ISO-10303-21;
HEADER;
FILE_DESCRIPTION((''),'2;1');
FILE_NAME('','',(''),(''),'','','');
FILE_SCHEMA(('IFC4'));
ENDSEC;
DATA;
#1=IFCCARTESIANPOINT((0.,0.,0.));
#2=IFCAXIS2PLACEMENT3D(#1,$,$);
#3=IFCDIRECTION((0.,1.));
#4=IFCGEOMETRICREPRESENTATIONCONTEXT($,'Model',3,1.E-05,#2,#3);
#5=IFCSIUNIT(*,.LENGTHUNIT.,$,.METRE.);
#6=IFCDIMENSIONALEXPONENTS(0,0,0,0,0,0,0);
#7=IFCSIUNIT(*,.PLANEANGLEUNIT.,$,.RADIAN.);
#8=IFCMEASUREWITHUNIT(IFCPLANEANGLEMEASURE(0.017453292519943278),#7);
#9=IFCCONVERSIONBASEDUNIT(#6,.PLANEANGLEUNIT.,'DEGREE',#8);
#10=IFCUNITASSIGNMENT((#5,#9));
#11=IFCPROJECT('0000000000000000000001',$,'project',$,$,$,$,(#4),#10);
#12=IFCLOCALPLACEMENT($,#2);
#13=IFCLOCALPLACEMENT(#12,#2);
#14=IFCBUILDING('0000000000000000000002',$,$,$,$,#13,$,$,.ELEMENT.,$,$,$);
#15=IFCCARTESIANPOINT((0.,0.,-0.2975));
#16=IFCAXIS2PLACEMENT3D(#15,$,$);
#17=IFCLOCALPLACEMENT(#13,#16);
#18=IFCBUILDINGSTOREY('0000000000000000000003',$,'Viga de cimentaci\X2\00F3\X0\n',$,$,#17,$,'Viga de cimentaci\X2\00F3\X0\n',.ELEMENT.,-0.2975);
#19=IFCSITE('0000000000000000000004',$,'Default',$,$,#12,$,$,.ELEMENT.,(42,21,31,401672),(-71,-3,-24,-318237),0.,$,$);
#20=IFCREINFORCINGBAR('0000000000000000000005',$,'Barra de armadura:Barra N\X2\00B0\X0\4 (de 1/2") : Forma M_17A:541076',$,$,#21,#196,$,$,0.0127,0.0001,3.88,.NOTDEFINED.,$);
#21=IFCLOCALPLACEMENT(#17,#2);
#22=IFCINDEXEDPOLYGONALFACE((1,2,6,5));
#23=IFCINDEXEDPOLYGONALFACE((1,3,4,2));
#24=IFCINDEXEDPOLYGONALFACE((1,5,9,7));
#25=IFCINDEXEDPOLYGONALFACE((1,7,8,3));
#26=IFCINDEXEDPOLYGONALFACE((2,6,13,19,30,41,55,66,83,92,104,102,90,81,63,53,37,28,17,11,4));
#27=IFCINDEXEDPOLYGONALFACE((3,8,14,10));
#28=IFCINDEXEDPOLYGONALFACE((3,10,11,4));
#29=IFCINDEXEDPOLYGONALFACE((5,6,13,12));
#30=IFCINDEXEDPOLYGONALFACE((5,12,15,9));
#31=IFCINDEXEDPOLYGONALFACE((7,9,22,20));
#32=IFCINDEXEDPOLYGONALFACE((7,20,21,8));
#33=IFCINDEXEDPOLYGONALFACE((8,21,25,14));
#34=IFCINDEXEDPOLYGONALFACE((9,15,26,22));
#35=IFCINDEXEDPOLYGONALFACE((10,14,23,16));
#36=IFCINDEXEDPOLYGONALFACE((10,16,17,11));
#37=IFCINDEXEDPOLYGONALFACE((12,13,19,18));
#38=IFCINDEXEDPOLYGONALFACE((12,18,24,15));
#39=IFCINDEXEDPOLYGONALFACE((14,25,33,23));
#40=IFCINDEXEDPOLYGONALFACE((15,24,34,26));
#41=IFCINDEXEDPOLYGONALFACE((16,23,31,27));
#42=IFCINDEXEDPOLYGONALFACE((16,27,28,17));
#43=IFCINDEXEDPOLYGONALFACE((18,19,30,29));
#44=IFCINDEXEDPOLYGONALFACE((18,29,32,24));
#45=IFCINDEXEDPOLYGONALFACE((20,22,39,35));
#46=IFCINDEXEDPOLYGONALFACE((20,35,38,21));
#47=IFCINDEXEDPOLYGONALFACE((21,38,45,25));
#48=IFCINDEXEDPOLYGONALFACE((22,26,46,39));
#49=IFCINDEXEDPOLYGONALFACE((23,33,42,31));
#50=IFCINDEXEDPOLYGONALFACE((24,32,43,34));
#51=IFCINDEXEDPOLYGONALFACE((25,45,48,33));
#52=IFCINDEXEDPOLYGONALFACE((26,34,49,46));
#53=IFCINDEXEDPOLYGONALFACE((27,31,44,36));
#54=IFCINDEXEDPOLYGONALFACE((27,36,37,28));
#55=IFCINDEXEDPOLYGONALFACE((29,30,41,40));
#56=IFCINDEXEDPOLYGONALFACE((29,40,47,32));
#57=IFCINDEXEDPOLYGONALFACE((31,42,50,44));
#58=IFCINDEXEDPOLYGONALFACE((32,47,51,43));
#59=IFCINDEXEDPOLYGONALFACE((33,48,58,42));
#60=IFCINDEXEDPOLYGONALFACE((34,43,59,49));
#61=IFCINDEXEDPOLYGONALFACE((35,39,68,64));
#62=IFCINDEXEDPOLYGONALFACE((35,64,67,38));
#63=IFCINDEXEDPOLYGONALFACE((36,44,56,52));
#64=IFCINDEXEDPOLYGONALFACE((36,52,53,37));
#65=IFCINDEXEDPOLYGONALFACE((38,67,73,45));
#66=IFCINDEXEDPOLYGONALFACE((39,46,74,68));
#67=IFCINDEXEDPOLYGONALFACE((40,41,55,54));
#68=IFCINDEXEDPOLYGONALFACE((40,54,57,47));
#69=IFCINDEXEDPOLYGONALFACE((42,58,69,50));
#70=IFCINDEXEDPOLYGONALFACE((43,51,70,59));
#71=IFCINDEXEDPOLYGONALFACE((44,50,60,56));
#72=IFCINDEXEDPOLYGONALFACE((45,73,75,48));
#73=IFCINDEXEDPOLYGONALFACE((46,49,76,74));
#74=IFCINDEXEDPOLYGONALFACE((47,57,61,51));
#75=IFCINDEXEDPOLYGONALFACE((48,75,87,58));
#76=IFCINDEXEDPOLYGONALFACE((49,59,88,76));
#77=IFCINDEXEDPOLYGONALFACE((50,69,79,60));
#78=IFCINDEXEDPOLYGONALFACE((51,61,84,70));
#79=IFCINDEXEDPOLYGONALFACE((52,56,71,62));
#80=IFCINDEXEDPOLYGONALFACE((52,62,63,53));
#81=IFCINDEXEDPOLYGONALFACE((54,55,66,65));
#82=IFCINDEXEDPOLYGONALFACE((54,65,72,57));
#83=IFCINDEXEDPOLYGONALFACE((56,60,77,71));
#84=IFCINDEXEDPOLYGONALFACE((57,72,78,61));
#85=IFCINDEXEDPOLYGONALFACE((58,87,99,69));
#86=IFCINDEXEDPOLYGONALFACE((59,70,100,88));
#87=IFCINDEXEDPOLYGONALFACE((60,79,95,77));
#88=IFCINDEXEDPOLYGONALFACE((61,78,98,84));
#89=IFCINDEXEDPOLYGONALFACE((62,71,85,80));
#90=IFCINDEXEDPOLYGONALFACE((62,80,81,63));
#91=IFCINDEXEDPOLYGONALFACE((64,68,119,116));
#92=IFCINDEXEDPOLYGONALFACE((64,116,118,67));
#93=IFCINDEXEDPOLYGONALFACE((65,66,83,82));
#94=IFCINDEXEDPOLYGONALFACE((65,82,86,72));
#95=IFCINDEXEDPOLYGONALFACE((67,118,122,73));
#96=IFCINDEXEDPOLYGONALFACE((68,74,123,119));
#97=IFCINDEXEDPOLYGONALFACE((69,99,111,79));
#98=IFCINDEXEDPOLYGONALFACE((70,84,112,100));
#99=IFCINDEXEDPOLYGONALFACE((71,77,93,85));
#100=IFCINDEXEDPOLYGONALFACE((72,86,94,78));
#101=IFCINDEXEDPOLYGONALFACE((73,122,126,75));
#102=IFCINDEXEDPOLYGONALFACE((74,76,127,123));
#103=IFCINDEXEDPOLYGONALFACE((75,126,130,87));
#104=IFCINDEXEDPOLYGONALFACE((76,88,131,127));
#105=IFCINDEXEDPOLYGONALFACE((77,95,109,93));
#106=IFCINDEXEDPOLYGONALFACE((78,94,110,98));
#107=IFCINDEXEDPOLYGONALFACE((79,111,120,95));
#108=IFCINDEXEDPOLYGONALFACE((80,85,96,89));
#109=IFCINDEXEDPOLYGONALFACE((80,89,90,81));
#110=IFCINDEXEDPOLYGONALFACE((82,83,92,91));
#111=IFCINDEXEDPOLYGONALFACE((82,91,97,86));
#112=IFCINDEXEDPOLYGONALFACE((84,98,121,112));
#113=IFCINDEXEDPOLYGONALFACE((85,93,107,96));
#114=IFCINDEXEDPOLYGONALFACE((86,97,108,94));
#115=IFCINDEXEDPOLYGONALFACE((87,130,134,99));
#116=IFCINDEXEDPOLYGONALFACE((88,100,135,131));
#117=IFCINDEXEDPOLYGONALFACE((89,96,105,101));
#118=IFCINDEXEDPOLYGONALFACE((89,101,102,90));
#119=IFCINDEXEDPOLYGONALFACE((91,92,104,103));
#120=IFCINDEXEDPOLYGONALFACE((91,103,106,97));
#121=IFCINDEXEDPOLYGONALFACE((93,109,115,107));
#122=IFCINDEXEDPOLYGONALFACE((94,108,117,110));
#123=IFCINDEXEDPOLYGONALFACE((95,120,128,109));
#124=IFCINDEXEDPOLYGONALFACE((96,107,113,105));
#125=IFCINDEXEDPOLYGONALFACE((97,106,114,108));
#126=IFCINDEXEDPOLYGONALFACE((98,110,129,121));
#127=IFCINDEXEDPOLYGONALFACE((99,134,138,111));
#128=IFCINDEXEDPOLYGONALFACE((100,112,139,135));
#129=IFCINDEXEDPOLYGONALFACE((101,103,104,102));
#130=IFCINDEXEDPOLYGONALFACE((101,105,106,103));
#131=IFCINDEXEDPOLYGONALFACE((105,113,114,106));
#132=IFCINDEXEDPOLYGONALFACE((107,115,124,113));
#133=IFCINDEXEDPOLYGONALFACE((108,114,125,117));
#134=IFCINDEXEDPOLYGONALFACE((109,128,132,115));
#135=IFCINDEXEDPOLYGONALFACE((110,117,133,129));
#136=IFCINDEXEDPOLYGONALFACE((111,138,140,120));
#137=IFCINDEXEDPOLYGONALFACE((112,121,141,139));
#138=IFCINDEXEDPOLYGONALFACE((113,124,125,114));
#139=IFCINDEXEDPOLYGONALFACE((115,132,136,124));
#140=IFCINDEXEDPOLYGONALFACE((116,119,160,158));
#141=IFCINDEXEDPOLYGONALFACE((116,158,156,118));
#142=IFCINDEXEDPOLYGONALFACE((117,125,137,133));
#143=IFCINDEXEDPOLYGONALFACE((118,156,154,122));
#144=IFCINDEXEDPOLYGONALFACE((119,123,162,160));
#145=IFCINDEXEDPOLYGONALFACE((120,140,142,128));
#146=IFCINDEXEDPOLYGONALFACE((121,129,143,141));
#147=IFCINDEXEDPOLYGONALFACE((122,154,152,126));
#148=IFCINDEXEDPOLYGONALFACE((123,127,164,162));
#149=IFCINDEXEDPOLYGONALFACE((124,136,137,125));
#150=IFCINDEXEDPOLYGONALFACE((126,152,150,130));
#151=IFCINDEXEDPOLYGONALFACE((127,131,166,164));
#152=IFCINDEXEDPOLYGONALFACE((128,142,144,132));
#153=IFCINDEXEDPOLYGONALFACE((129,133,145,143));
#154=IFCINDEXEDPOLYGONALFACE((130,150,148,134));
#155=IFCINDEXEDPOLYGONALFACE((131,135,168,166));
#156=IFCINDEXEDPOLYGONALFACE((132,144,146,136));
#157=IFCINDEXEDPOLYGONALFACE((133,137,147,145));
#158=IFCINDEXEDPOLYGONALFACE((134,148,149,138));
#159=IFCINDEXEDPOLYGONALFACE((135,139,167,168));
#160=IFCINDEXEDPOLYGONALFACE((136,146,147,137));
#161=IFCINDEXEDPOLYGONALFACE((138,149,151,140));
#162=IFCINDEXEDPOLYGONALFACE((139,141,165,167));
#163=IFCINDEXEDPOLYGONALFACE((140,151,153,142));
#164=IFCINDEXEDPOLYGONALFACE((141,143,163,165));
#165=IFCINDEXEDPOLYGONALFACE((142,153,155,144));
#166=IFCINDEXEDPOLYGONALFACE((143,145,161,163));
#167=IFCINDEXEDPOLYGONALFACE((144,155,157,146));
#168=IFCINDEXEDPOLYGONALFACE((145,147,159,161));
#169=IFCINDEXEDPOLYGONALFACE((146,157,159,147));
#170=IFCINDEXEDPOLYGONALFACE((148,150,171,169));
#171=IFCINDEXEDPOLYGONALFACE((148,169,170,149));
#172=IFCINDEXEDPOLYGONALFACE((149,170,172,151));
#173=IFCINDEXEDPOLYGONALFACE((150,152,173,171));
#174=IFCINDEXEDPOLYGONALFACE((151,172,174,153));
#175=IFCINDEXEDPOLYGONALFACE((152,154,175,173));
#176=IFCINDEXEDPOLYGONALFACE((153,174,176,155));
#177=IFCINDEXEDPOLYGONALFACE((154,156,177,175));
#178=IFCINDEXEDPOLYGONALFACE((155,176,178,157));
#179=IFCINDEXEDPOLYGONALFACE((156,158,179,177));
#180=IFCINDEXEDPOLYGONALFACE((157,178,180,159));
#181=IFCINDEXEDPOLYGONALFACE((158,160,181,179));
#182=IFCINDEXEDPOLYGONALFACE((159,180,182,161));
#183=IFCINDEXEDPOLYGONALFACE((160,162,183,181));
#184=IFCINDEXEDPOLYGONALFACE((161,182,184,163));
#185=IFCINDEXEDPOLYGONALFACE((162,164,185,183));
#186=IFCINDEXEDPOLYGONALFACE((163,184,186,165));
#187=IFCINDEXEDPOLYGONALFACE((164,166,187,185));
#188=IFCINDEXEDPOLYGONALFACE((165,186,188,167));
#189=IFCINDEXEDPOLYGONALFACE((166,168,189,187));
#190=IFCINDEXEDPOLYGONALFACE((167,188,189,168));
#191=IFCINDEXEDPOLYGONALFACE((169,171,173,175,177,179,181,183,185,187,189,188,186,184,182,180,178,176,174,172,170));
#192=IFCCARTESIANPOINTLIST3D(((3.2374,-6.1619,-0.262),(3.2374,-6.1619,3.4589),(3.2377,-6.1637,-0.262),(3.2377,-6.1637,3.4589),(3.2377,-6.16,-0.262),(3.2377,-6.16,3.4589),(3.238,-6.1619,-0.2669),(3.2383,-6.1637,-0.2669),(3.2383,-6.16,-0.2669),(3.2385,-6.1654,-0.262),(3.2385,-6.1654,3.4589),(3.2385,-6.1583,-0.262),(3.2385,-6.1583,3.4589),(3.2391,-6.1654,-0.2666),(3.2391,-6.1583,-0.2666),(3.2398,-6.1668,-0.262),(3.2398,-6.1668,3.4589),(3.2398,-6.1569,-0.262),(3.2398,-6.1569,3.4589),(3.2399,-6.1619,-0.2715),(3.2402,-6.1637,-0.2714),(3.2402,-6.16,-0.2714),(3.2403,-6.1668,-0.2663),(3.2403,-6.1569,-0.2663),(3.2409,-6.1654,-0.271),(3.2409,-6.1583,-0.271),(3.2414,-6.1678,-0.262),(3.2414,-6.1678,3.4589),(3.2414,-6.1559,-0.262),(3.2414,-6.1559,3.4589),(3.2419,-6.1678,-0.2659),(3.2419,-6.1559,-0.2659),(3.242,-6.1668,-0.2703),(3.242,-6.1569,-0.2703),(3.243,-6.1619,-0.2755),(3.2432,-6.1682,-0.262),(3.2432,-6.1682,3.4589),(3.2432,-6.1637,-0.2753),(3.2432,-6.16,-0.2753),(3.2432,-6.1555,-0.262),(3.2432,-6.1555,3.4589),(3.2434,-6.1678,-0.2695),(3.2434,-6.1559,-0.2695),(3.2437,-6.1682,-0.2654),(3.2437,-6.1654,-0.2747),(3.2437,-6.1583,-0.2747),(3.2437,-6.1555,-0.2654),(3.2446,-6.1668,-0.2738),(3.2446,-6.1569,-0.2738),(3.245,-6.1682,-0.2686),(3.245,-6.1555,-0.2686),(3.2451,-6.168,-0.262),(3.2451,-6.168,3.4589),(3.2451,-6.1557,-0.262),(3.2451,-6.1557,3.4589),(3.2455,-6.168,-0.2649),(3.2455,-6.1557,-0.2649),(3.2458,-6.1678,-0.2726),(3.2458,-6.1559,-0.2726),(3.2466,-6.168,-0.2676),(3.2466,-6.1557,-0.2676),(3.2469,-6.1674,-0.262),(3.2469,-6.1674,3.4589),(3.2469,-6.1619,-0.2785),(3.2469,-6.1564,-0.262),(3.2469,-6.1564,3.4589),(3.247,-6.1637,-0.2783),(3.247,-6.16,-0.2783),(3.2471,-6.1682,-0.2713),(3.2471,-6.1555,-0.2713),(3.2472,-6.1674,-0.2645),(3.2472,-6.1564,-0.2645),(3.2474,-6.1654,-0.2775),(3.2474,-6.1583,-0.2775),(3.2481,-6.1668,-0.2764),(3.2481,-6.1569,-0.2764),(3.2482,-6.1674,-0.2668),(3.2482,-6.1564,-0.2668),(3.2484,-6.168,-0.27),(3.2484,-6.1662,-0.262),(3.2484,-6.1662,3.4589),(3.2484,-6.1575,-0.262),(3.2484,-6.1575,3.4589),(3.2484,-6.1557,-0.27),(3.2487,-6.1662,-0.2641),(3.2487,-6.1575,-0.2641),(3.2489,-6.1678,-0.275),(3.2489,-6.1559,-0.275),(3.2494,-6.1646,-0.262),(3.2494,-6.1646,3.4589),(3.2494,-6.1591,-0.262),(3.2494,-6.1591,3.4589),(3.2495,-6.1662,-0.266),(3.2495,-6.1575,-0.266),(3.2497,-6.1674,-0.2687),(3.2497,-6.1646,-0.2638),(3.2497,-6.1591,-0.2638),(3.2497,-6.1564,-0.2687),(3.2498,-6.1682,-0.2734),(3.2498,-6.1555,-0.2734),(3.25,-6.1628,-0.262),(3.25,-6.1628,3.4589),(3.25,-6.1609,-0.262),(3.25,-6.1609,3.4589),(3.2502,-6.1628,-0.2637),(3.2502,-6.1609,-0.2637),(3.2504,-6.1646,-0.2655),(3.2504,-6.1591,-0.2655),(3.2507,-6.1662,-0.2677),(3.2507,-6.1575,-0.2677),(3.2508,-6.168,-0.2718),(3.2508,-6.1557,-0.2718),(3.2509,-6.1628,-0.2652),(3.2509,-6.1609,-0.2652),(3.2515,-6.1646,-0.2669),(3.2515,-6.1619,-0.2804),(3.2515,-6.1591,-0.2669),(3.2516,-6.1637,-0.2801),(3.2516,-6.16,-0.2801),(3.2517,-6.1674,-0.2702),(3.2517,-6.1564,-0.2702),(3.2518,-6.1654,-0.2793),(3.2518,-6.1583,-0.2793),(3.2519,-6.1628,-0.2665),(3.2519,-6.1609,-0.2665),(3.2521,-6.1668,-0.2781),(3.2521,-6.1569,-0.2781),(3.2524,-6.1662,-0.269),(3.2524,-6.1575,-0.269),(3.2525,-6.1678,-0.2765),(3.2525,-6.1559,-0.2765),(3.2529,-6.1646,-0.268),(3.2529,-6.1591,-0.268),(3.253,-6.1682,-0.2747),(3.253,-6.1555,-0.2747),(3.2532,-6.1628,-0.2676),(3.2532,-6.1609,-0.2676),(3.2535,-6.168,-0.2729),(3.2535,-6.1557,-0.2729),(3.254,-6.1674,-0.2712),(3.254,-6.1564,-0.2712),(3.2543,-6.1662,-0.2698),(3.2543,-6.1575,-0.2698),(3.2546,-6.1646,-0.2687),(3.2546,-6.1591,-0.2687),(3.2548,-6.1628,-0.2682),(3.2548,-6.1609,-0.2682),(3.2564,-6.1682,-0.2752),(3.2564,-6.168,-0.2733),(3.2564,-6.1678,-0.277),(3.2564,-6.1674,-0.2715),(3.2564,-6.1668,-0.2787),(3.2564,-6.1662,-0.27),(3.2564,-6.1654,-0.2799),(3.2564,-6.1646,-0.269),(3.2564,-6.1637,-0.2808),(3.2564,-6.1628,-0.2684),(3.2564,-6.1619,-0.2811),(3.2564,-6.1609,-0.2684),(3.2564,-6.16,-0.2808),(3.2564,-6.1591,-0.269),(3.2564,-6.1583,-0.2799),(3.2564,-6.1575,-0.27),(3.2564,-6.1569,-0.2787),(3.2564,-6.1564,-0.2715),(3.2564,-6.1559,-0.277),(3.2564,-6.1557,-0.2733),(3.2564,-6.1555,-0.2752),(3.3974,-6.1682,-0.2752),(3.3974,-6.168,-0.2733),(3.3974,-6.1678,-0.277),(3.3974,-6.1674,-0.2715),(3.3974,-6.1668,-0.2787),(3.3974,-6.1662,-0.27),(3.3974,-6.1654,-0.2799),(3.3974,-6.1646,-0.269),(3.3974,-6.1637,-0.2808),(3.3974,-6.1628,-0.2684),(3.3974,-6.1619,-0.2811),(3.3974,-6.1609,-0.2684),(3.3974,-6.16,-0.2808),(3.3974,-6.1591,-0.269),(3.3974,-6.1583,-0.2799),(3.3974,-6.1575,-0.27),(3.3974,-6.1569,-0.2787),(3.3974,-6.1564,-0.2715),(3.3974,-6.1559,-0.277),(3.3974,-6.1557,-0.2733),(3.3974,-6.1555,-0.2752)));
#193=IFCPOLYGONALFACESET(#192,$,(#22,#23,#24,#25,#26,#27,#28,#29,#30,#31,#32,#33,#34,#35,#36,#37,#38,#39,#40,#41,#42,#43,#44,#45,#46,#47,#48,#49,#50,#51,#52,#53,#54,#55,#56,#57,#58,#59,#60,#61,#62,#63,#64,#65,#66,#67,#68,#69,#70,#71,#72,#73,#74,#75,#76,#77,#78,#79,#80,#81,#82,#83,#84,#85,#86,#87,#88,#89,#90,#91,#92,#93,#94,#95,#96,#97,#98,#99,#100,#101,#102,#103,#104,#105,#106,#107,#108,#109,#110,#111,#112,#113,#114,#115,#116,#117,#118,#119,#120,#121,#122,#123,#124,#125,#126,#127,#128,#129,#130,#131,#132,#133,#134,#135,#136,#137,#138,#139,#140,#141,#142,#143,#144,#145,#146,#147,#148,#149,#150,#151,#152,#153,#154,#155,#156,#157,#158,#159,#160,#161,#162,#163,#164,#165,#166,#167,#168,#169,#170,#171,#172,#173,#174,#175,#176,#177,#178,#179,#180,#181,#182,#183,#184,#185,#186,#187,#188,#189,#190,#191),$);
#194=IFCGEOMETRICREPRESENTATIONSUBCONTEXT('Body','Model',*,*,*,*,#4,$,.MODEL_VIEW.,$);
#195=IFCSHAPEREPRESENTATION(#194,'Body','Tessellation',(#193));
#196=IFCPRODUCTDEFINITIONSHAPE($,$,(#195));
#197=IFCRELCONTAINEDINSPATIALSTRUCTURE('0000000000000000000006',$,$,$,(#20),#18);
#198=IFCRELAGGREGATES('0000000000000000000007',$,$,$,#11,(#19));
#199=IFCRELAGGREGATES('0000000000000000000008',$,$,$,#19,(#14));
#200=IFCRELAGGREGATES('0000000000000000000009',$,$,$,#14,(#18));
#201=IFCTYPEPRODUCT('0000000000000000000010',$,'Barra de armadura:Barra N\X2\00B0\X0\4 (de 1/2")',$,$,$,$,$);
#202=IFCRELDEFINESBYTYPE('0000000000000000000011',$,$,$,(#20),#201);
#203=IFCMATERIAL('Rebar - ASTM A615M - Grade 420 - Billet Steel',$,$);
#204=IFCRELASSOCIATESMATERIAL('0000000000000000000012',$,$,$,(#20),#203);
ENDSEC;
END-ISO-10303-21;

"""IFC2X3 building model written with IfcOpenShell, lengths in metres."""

from ifc_helpers import new_model, entity, si_unit, converted_unit, direction, frame, origin, place, context, subcontext, project, spatial, material, type_object, element, save


model = new_model("IFC2X3")

# Units and contexts
model_context = context("Model", 3, precision=1e-05, world=origin(), true_north=direction((0.0, 1.0)))
body_context = subcontext(model_context, "Body", "Model", "MODEL_VIEW")
ifc_project = project(units=[si_unit("LENGTHUNIT", "METRE"), converted_unit("PLANEANGLEUNIT", "DEGREE", entity("IfcPlaneAngleMeasure", 0.017453292519943278), si_unit("PLANEANGLEUNIT", "RADIAN"), dimensions=[0, 0, 0, 0, 0, 0, 0])], contexts=[model_context])

# Site, building, storey
site_placement = place(None, origin())
site = spatial("IfcSite", under=ifc_project, at=site_placement, Name="Default", CompositionType="ELEMENT", RefLatitude=(42, 21, 31, 401672), RefLongitude=(-71, -3, -24, -318237), RefElevation=0.0)
building_placement = place(site_placement, origin())
building = spatial("IfcBuilding", under=site, at=building_placement, CompositionType="ELEMENT")
storey_placement = place(building_placement, frame((0.0, 0.0, -0.2975)))
storey = spatial("IfcBuildingStorey", under=building, at=storey_placement, Name="Viga de cimentación", LongName="Viga de cimentación", CompositionType="ELEMENT", Elevation=-0.2975)

# Reinforcing bar
ifc_material_1 = material(Name="Rebar - ASTM A615M - Grade 420 - Billet Steel")
type_product_1 = type_object("IfcTypeProduct", Name="Barra de armadura:Barra N°4 (de 1/2\")")
reinforcing_bar_1_placement = place(storey_placement, origin())
element("IfcReinforcingBar", 1, at=reinforcing_bar_1_placement, inside=storey, type_object=type_product_1, material=ifc_material_1, Name="Barra de armadura:Barra N°4 (de 1/2\") : Forma M_17A:541076", BarLength=3.88, BarRole="NOTDEFINED", CrossSectionArea=0.0001, NominalDiameter=0.0127, context=body_context, shape_type="AdvancedSweptSolid", body=[
    entity("IfcSweptDiskSolid", entity("IfcCompositeCurve", [entity("IfcCompositeCurveSegment", "CONTINUOUS", True, entity("IfcPolyline", [entity("IfcCartesianPoint", [3.2437, -6.1619, 3.4589]), entity("IfcCartesianPoint", [3.2437, -6.1619, -0.262])])), entity("IfcCompositeCurveSegment", "CONTINUOUS", True, entity("IfcTrimmedCurve", entity("IfcCircle", entity("IfcAxis2Placement3D", entity("IfcCartesianPoint", [3.2564, -6.1619, -0.262]), entity("IfcDirection", [0.0, -1.0, 0.0]), entity("IfcDirection", [0.0, 0.0, -1.0])), 0.0127), [entity("IfcParameterValue", 270.0)], [entity("IfcParameterValue", 360.0)], True, "PARAMETER")), entity("IfcCompositeCurveSegment", "CONTINUOUS", True, entity("IfcPolyline", [entity("IfcCartesianPoint", [3.2564, -6.1619, -0.2747]), entity("IfcCartesianPoint", [3.3974, -6.1619, -0.2747])]))], False), 0.0063, None, 0.0, 92.0),
])

save(model, "model.ifc")
